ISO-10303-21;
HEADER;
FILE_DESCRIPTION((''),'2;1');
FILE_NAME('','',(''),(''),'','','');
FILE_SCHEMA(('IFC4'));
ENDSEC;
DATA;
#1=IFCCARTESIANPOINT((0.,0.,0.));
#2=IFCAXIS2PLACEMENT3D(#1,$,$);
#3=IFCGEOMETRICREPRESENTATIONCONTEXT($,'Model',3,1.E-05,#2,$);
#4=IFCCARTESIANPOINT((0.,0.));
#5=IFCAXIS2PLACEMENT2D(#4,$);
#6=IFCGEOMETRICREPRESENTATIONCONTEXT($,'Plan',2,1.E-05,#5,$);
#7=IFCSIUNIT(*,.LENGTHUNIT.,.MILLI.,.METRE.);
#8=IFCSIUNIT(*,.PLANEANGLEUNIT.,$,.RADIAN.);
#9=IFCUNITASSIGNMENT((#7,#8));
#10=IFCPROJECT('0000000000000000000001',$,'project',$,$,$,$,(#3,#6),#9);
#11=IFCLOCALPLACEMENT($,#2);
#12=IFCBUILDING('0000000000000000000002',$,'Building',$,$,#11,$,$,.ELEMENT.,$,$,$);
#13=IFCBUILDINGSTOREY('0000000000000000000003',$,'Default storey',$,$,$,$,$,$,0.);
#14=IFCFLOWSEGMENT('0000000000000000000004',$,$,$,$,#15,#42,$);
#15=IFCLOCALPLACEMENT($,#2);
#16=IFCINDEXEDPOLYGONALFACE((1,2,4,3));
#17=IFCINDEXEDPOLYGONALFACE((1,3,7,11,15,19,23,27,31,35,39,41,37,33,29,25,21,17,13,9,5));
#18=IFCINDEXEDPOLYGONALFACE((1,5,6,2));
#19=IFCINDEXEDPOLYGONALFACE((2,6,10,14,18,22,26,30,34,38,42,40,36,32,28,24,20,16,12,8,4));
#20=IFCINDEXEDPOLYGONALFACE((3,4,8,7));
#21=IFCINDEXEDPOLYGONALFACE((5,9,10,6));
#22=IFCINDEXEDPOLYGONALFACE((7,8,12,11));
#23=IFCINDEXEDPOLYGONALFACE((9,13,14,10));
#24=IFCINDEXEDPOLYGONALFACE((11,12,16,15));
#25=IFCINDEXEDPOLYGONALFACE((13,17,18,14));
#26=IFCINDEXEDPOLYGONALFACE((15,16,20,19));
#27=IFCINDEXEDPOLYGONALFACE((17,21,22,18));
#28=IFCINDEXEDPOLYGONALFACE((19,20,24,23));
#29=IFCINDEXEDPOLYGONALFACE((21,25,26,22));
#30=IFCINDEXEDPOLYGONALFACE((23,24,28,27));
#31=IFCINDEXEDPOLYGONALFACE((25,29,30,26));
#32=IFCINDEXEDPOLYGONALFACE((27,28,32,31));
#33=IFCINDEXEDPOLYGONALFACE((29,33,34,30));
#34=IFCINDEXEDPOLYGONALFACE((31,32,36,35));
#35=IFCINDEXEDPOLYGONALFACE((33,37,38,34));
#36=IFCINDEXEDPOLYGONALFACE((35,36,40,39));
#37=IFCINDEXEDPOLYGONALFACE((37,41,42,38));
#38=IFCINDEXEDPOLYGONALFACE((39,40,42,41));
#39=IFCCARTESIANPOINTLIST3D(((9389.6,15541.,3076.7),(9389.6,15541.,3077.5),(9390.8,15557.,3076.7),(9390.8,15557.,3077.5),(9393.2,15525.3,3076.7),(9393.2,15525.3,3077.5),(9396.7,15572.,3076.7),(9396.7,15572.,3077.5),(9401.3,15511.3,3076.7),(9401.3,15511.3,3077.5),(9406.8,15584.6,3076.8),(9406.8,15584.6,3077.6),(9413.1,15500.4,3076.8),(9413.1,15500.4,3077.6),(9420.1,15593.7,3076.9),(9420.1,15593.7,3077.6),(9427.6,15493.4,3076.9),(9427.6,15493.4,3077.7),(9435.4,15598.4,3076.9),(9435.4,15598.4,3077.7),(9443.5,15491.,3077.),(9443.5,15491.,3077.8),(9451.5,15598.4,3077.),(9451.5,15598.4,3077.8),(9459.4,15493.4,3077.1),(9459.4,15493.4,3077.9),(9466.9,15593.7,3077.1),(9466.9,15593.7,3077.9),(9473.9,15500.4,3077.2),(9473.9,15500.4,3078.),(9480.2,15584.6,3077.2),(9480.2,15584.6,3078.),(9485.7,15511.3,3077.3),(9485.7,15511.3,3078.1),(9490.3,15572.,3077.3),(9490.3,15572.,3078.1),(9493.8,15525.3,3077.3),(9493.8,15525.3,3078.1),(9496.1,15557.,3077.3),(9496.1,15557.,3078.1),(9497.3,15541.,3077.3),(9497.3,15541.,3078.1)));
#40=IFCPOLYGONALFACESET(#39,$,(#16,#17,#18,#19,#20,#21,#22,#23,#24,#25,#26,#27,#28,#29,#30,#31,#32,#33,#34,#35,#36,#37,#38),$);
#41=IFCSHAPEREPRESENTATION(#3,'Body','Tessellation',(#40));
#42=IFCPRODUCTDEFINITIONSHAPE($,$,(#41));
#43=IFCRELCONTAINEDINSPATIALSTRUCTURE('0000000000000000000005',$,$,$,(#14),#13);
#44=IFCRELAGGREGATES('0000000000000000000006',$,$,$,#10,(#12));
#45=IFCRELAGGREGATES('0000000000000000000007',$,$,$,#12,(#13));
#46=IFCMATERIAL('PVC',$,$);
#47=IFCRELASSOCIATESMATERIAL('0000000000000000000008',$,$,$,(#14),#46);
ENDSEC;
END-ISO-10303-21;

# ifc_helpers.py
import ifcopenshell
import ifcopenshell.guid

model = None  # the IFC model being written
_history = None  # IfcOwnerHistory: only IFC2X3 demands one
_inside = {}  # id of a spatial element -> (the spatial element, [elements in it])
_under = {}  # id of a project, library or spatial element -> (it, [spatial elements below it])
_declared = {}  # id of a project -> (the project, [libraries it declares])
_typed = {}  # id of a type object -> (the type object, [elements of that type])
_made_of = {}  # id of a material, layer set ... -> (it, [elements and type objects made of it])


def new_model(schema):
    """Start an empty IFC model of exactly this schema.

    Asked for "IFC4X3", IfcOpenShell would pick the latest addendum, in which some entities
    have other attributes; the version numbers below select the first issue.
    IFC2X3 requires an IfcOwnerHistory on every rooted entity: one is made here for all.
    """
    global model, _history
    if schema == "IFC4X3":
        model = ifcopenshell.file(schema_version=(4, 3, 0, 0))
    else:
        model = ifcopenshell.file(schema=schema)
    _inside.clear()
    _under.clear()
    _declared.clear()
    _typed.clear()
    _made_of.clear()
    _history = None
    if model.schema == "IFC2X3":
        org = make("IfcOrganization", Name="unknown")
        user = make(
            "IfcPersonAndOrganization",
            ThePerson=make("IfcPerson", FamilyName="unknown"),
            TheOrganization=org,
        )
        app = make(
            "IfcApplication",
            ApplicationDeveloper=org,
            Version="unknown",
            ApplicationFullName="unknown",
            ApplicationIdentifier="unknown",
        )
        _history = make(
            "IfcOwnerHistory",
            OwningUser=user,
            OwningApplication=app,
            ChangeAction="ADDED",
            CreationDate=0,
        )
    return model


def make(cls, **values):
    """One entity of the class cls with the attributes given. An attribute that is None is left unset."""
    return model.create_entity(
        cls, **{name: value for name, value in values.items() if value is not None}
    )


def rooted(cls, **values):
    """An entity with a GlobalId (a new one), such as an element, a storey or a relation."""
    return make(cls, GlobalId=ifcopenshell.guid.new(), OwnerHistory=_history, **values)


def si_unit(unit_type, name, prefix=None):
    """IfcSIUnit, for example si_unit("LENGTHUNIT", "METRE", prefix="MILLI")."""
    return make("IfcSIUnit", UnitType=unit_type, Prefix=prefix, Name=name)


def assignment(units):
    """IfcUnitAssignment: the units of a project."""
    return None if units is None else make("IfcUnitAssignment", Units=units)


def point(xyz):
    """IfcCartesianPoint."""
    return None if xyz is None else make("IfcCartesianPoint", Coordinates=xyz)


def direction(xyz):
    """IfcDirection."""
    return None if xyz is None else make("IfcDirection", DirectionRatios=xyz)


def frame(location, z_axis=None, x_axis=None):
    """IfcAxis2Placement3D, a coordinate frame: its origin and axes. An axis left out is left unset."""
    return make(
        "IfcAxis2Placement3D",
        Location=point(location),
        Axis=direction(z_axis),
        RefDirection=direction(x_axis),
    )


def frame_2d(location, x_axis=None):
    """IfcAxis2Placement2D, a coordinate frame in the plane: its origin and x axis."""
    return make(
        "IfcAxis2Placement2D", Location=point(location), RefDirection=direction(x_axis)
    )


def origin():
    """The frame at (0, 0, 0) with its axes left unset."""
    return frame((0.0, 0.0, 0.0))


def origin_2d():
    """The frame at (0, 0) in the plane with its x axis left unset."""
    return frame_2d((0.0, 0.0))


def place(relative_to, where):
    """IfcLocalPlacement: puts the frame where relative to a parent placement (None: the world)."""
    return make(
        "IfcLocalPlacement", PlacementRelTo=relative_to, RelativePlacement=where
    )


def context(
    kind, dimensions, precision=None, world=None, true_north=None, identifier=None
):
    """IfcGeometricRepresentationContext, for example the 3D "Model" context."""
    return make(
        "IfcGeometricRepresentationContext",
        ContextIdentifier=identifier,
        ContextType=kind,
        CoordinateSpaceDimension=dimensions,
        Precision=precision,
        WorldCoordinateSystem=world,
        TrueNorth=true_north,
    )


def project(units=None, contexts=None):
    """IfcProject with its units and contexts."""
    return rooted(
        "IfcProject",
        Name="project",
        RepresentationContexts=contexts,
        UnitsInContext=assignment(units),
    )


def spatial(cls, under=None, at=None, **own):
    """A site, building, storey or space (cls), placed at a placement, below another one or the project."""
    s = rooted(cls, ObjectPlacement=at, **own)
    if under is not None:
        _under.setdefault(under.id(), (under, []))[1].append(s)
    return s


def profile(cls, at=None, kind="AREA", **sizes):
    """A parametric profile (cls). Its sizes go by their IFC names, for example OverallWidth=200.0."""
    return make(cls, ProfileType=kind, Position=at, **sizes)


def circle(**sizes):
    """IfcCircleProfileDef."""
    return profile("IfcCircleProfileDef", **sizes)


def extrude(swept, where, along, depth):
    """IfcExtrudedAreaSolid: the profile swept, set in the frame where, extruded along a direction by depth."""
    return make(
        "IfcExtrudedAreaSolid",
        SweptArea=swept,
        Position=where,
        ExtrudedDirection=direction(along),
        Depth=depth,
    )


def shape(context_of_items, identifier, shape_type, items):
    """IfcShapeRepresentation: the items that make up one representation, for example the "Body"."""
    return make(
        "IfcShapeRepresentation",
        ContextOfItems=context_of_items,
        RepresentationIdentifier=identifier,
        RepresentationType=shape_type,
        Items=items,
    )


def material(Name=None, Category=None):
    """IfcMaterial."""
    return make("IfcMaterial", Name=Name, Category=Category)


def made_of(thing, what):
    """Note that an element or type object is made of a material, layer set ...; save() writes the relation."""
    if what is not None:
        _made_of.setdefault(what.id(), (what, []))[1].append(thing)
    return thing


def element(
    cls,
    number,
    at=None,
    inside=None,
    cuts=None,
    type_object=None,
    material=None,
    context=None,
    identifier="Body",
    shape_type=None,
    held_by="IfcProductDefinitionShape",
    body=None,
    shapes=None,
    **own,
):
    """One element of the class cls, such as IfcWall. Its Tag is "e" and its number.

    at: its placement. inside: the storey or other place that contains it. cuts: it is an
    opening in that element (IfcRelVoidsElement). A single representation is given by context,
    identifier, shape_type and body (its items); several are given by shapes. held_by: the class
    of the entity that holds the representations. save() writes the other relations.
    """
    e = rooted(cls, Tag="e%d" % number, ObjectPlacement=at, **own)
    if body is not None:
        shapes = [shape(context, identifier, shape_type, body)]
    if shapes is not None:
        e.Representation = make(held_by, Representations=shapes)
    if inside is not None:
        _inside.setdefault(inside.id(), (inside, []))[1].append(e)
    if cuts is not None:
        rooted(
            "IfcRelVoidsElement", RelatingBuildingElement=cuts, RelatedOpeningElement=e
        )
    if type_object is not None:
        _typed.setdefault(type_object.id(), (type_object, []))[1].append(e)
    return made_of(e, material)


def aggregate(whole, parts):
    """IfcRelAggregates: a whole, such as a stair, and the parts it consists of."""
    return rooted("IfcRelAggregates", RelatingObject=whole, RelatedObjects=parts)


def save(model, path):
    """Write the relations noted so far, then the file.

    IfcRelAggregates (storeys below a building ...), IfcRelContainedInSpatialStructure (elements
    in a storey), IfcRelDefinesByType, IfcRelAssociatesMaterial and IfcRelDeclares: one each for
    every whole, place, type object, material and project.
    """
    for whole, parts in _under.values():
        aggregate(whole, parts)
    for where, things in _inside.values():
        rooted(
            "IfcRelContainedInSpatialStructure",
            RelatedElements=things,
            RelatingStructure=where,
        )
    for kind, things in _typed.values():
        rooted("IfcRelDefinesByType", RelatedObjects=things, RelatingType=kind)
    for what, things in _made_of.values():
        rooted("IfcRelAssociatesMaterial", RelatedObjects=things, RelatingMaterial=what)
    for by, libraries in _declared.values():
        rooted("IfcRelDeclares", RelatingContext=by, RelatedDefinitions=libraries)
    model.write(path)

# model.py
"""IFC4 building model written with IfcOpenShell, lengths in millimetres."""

from ifc_helpers import new_model, si_unit, frame, origin, origin_2d, place, context, project, spatial, circle, extrude, material, element, save


model = new_model("IFC4")

# Units and contexts
model_context = context("Model", 3, precision=1e-05, world=origin())
plan_context = context("Plan", 2, precision=1e-05, world=origin_2d())
ifc_project = project(units=[si_unit("LENGTHUNIT", "METRE", prefix="MILLI"), si_unit("PLANEANGLEUNIT", "RADIAN")], contexts=[model_context, plan_context])

# Building, storey
placement = place(None, origin())
building = spatial("IfcBuilding", under=ifc_project, at=placement, Name="Building", CompositionType="ELEMENT")
storey = spatial("IfcBuildingStorey", under=building, Name="Default storey", Elevation=0.0)

# Flow segment
ifc_material = material(Name="PVC")
element("IfcFlowSegment", 1, at=placement, inside=storey, material=ifc_material, context=model_context, shape_type="SweptSolid", body=[
    extrude(circle(Radius=54.0, at=origin_2d()), frame((9443.5, 15545.0, 3077.8), z_axis=(0.004938, 0.0, -0.790016), x_axis=(0.0, -4.937599, 0.0)), (0.0, 0.0, 1.0), 0.8),
])

save(model, "model.ifc")
